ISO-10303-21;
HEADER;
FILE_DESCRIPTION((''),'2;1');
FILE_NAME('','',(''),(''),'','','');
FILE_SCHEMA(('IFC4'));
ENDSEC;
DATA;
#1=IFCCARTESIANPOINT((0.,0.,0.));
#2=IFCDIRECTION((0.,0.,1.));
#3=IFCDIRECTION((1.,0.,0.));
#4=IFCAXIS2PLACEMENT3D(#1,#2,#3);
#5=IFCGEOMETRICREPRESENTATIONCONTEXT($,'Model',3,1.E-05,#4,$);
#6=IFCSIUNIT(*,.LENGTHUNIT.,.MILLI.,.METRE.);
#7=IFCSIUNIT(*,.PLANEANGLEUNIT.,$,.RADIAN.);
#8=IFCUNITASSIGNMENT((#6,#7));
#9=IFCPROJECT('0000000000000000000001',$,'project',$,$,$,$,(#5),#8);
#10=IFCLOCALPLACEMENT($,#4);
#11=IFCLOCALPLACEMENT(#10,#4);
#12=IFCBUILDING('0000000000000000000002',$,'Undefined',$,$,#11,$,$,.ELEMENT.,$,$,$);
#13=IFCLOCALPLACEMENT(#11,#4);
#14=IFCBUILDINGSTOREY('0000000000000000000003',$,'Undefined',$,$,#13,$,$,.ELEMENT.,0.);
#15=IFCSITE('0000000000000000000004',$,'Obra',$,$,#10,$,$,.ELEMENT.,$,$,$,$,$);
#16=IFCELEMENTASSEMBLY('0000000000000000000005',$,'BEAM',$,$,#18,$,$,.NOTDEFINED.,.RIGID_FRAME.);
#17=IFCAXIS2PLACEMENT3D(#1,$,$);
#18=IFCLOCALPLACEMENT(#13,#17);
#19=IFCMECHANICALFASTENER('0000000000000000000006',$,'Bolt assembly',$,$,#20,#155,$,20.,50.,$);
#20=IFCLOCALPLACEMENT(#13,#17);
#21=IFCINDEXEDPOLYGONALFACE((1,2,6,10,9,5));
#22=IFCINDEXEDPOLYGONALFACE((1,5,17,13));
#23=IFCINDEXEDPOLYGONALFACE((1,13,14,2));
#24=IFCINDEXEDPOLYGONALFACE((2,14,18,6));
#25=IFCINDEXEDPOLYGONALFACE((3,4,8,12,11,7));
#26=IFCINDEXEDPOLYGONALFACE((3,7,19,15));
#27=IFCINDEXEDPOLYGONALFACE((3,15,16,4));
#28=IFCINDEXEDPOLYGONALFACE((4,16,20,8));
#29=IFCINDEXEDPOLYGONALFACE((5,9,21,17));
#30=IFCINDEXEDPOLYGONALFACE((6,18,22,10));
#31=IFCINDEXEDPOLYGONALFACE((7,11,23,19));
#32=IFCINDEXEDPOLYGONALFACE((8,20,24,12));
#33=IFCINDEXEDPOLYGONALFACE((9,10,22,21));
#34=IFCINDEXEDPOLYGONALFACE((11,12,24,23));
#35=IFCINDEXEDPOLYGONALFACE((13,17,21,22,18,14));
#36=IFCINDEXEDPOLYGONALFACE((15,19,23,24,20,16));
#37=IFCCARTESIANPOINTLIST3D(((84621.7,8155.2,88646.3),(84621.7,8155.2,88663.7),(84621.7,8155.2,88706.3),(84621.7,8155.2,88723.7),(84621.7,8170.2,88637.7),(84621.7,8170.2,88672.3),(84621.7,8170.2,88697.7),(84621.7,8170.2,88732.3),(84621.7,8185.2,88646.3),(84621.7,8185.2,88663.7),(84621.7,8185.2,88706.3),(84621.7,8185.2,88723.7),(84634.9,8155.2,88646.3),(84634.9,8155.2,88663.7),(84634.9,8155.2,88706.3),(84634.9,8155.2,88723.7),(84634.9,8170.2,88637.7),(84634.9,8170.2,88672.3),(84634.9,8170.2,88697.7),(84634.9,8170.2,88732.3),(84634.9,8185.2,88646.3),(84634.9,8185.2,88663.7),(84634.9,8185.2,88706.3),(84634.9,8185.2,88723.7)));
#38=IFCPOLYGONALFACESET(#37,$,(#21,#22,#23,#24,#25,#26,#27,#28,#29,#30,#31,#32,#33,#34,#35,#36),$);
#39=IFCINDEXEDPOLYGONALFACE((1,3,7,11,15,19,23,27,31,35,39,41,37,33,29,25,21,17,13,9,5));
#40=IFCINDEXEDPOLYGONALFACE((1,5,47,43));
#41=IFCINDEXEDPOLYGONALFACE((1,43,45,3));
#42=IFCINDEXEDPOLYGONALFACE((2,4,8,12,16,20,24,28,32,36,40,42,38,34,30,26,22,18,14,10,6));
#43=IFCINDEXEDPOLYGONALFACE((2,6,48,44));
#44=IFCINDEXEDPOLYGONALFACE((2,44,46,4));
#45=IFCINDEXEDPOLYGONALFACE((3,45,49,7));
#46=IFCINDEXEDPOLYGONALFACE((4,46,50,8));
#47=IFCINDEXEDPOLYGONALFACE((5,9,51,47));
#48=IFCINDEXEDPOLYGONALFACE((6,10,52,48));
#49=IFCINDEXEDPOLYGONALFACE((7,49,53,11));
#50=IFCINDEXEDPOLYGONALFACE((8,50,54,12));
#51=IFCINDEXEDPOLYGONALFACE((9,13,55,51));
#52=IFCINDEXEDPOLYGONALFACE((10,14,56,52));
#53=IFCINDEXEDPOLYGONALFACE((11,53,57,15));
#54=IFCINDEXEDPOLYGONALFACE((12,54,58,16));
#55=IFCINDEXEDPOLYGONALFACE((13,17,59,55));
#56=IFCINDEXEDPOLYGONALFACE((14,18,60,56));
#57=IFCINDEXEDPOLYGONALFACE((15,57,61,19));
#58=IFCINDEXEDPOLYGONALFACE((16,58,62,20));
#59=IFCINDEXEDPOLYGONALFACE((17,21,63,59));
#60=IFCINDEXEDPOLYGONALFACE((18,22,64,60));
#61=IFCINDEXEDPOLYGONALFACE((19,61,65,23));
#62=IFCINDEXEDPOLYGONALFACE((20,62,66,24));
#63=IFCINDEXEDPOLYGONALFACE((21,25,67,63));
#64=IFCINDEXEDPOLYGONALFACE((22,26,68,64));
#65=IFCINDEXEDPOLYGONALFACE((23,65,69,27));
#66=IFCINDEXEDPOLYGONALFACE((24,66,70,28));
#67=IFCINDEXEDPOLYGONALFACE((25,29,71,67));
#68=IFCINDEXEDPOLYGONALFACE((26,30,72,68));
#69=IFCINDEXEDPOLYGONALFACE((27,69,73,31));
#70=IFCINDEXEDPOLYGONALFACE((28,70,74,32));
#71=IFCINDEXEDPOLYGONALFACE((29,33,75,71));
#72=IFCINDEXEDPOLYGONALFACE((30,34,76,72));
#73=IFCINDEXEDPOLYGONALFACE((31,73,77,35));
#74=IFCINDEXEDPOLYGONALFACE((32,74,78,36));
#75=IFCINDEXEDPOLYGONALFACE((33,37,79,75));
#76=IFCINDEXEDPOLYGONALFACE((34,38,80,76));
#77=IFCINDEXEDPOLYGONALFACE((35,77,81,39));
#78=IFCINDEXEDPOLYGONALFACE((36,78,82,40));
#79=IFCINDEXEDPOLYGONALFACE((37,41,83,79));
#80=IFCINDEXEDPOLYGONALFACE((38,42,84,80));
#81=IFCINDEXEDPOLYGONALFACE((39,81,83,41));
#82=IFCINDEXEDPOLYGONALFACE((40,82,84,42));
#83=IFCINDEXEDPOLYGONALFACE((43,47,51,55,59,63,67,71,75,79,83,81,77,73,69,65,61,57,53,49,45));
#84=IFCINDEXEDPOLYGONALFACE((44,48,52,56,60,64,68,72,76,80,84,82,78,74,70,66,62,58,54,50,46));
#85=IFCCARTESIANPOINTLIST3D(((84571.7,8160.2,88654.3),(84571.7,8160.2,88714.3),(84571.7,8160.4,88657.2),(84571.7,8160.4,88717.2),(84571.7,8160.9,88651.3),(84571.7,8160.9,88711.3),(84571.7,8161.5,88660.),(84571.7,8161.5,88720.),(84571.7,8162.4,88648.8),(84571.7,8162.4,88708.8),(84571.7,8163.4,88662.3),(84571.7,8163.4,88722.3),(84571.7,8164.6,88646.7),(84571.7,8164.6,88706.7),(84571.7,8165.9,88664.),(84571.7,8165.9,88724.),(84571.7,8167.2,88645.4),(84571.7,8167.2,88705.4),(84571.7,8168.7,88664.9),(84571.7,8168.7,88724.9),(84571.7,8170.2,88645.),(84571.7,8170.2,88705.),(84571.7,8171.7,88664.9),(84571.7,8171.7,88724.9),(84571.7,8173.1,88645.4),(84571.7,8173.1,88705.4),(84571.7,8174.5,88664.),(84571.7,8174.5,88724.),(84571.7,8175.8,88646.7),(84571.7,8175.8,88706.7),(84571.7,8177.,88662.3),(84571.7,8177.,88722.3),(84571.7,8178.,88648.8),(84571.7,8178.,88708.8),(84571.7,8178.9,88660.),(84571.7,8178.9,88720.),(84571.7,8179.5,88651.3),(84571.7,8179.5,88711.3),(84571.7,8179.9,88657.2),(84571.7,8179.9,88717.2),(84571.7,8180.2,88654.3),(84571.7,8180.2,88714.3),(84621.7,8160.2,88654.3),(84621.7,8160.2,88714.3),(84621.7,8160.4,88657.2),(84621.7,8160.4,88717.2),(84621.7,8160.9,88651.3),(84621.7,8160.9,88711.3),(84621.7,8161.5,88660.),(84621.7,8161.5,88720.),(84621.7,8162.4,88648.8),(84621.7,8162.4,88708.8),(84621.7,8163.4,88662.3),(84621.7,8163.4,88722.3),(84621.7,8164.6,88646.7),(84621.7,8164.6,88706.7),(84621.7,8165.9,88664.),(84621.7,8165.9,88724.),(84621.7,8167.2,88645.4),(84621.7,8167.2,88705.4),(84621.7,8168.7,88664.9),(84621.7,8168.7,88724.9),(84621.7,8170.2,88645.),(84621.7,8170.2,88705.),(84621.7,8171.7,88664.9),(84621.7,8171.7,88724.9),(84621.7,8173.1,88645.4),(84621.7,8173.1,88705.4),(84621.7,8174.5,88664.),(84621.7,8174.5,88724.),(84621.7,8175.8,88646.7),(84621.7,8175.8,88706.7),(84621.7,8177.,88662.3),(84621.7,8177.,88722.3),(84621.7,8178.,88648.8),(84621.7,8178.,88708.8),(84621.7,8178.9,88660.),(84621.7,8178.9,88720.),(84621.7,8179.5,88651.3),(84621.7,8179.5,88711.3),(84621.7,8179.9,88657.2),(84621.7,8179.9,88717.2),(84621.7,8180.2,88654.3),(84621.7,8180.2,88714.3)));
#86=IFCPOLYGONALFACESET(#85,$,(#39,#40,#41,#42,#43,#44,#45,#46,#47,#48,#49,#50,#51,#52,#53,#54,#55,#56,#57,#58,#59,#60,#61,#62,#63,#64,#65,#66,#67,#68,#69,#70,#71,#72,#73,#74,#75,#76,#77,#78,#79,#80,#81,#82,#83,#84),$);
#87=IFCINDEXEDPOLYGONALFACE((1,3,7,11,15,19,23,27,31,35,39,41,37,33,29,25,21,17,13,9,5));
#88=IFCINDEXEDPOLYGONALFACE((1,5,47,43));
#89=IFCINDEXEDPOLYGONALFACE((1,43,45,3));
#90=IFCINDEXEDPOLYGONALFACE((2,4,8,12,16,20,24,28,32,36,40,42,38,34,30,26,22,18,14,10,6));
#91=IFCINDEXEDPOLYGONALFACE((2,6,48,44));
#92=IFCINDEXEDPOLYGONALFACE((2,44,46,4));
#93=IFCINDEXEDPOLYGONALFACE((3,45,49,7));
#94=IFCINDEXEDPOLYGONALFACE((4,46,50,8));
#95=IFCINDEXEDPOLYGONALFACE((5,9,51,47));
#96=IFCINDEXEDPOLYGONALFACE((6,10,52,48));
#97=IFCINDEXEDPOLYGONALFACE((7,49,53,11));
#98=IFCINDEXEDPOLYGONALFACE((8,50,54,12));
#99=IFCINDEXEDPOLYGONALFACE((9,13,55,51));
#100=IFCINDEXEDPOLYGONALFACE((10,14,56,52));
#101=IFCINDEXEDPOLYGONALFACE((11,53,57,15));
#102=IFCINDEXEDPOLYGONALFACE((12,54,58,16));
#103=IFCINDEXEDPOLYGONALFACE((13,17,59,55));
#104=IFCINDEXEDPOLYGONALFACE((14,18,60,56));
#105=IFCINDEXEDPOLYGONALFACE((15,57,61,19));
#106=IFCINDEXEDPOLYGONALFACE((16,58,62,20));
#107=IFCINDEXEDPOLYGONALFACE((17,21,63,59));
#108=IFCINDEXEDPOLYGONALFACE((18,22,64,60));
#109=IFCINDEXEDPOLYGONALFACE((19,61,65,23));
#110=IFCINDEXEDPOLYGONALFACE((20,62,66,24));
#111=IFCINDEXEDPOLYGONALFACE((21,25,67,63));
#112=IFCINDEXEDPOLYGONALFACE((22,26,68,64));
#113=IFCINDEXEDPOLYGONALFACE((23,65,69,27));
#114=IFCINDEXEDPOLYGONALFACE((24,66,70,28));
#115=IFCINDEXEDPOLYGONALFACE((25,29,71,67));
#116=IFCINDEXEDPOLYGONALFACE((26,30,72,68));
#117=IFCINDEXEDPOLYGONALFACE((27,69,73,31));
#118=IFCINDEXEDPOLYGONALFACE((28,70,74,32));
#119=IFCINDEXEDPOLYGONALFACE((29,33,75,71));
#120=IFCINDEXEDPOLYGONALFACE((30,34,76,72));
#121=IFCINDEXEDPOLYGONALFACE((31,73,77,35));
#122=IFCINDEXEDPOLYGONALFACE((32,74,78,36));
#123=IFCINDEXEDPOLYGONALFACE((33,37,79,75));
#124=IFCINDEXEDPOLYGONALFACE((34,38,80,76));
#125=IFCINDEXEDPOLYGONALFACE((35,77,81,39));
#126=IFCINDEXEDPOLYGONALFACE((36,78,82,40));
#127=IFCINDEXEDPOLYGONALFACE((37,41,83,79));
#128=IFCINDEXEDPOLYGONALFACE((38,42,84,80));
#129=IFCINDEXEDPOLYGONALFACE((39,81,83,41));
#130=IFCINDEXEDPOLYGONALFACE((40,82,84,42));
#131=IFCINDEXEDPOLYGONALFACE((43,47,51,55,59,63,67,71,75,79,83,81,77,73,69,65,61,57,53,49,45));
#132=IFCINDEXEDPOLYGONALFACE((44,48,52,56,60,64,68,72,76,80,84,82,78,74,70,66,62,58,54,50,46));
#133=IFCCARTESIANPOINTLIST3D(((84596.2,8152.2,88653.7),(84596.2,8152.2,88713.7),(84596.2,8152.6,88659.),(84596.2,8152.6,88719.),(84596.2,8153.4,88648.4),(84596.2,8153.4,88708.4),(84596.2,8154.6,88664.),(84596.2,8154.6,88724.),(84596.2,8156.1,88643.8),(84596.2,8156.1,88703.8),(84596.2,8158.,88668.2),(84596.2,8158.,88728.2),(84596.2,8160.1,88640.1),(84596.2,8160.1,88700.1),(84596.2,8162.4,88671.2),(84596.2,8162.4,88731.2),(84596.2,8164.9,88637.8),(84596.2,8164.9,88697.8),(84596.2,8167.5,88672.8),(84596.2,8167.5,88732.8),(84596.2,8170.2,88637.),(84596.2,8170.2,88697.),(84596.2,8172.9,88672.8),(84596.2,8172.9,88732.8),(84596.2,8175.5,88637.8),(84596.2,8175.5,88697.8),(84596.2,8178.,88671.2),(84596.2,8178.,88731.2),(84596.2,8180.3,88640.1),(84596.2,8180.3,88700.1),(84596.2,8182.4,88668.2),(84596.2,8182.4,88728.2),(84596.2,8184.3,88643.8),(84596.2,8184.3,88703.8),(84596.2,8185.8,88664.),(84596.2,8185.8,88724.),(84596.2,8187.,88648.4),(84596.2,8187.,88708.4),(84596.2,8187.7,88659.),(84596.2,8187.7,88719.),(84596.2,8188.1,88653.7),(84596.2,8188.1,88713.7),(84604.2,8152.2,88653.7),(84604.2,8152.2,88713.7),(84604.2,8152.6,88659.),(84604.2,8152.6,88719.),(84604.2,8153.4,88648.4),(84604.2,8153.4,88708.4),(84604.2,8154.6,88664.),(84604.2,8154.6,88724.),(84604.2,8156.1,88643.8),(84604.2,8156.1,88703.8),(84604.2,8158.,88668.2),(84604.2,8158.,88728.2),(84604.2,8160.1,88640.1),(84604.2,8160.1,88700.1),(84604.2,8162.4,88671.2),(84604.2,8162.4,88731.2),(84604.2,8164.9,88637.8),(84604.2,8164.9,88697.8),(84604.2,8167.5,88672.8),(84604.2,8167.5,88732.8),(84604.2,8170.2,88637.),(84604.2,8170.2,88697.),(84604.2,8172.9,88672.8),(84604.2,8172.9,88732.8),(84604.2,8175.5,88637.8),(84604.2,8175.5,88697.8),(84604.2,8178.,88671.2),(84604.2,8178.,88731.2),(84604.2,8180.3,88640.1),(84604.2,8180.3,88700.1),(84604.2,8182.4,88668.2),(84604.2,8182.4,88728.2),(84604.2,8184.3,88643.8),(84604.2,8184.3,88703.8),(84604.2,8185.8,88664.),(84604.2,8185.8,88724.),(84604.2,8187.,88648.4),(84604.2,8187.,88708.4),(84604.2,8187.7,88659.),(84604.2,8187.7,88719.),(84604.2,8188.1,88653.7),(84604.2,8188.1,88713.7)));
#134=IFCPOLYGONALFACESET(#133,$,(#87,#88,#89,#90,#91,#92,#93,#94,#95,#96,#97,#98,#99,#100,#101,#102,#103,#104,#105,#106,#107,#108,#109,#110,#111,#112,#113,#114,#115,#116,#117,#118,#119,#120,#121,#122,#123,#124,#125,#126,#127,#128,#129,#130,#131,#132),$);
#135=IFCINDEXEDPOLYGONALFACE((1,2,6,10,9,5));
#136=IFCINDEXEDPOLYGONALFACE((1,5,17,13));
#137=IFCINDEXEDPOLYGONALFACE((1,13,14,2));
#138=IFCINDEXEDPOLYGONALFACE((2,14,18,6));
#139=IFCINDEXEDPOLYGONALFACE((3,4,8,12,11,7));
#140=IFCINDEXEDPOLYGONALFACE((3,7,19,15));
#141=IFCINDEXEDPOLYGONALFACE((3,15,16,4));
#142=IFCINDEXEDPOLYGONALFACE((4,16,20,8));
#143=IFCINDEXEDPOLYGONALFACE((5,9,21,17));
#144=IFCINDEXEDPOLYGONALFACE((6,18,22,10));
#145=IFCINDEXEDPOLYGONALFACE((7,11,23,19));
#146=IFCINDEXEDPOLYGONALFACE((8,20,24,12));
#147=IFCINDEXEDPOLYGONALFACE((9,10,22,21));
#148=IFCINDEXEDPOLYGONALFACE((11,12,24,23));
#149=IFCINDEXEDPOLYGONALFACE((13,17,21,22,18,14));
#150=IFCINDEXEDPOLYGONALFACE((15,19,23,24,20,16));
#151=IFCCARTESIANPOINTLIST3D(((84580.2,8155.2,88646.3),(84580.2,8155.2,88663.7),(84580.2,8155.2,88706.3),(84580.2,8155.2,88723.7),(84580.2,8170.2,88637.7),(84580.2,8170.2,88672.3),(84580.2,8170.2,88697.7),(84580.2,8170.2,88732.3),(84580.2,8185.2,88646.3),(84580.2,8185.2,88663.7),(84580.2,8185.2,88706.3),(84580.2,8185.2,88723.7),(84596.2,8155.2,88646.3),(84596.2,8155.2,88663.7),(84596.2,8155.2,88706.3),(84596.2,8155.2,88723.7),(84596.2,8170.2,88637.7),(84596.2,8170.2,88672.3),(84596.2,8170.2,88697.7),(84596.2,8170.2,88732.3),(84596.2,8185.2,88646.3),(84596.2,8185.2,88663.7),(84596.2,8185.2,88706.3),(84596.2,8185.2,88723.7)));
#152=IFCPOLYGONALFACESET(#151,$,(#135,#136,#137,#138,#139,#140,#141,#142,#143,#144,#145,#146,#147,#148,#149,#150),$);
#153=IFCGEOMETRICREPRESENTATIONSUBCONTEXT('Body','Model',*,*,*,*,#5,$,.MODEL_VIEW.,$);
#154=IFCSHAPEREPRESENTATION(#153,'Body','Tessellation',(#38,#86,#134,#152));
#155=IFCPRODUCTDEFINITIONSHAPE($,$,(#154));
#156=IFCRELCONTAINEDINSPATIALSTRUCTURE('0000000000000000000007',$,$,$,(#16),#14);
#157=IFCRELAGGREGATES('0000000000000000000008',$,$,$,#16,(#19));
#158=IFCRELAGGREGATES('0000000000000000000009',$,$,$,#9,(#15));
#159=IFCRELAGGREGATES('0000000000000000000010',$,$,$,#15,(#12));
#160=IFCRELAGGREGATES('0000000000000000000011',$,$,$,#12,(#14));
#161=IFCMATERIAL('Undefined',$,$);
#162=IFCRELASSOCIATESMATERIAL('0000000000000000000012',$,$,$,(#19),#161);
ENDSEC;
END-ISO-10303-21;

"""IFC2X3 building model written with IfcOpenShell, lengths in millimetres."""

from ifc_helpers import new_model, si_unit, frame, origin_with_axes, origin_2d_with_axis, place, context, subcontext, project, spatial, polyline, circle, outline, extrude, source, transform, mapped, material, element, aggregate, save


model = new_model("IFC2X3")

# Units and contexts
model_context = context("Model", 3, precision=1e-05, world=origin_with_axes())
body_context = subcontext(model_context, "Body", "Model", "MODEL_VIEW")
ifc_project = project(units=[si_unit("LENGTHUNIT", "METRE", prefix="MILLI"), si_unit("PLANEANGLEUNIT", "RADIAN")], contexts=[model_context])

# Site, building, storey
site_placement = place(None, origin_with_axes())
site = spatial("IfcSite", under=ifc_project, at=site_placement, Name="Obra", CompositionType="ELEMENT")
building_placement = place(site_placement, origin_with_axes())
building = spatial("IfcBuilding", under=site, at=building_placement, Name="Undefined", CompositionType="ELEMENT")
storey_placement = place(building_placement, origin_with_axes())
storey = spatial("IfcBuildingStorey", under=building, at=storey_placement, Name="Undefined", CompositionType="ELEMENT", Elevation=0.0)

# Shared definitions
ifc_material_1 = material(Name="Undefined")

# Element assembly, mechanical fastener
assembly_1_placement = place(storey_placement, origin_with_axes())
assembly_1 = element("IfcElementAssembly", 1, at=assembly_1_placement, inside=storey, Name="BEAM", AssemblyPlace="NOTDEFINED", PredefinedType="RIGID_FRAME")
shared_shape_1 = source(origin_with_axes(), body_context, "Body", "SweptSolid", [
    extrude(outline(polyline([(17.3, 0.0), (8.7, 15.0), (-8.7, 15.0), (-17.3, 0.0), (-8.7, -15.0), (8.7, -15.0), (17.3, 0.0)])), frame((0.0, -27.0, 0.0), z_axis=(0.0, 1.0, 0.0), x_axis=(1.0, 0.0, 0.0)), (0.0, 0.0, 1.0), 13.2),
    extrude(circle(Radius=10.0, at=origin_2d_with_axis()), frame((0.0, -13.8, 0.0), z_axis=(0.0, 1.0, 0.0), x_axis=(1.0, 0.0, 0.0)), (0.0, 0.0, 1.0), 50.0),
    extrude(circle(Radius=18.0, at=origin_2d_with_axis()), frame((0.0, 3.7, 0.0), z_axis=(0.0, 1.0, 0.0), x_axis=(1.0, 0.0, 0.0)), (0.0, 0.0, 1.0), 8.0),
    extrude(outline(polyline([(17.3, 0.0), (8.7, 15.0), (-8.7, 15.0), (-17.3, 0.0), (-8.7, -15.0), (8.7, -15.0), (17.3, 0.0)])), frame((0.0, 11.7, 0.0), z_axis=(0.0, 1.0, 0.0), x_axis=(1.0, 0.0, 0.0)), (0.0, 0.0, 1.0), 16.0),
])
mechanical_fastener_1_placement = place(assembly_1_placement, frame((84607.9, 8130.2, 88850.0), z_axis=(0.0, 1.0, 0.0), x_axis=(0.0, 0.0, -1.0)))
mechanical_fastener_1 = element("IfcMechanicalFastener", 2, at=mechanical_fastener_1_placement, material=ifc_material_1, Name="Bolt assembly", NominalDiameter=20.0, NominalLength=50.0, context=body_context, shape_type="MappedRepresentation", body=[
    mapped(shared_shape_1, transform((135.0, 0.0, 40.0))),
    mapped(shared_shape_1, transform((195.0, 0.0, 40.0))),
])
aggregate(assembly_1, [mechanical_fastener_1])

save(model, "model.ifc")
